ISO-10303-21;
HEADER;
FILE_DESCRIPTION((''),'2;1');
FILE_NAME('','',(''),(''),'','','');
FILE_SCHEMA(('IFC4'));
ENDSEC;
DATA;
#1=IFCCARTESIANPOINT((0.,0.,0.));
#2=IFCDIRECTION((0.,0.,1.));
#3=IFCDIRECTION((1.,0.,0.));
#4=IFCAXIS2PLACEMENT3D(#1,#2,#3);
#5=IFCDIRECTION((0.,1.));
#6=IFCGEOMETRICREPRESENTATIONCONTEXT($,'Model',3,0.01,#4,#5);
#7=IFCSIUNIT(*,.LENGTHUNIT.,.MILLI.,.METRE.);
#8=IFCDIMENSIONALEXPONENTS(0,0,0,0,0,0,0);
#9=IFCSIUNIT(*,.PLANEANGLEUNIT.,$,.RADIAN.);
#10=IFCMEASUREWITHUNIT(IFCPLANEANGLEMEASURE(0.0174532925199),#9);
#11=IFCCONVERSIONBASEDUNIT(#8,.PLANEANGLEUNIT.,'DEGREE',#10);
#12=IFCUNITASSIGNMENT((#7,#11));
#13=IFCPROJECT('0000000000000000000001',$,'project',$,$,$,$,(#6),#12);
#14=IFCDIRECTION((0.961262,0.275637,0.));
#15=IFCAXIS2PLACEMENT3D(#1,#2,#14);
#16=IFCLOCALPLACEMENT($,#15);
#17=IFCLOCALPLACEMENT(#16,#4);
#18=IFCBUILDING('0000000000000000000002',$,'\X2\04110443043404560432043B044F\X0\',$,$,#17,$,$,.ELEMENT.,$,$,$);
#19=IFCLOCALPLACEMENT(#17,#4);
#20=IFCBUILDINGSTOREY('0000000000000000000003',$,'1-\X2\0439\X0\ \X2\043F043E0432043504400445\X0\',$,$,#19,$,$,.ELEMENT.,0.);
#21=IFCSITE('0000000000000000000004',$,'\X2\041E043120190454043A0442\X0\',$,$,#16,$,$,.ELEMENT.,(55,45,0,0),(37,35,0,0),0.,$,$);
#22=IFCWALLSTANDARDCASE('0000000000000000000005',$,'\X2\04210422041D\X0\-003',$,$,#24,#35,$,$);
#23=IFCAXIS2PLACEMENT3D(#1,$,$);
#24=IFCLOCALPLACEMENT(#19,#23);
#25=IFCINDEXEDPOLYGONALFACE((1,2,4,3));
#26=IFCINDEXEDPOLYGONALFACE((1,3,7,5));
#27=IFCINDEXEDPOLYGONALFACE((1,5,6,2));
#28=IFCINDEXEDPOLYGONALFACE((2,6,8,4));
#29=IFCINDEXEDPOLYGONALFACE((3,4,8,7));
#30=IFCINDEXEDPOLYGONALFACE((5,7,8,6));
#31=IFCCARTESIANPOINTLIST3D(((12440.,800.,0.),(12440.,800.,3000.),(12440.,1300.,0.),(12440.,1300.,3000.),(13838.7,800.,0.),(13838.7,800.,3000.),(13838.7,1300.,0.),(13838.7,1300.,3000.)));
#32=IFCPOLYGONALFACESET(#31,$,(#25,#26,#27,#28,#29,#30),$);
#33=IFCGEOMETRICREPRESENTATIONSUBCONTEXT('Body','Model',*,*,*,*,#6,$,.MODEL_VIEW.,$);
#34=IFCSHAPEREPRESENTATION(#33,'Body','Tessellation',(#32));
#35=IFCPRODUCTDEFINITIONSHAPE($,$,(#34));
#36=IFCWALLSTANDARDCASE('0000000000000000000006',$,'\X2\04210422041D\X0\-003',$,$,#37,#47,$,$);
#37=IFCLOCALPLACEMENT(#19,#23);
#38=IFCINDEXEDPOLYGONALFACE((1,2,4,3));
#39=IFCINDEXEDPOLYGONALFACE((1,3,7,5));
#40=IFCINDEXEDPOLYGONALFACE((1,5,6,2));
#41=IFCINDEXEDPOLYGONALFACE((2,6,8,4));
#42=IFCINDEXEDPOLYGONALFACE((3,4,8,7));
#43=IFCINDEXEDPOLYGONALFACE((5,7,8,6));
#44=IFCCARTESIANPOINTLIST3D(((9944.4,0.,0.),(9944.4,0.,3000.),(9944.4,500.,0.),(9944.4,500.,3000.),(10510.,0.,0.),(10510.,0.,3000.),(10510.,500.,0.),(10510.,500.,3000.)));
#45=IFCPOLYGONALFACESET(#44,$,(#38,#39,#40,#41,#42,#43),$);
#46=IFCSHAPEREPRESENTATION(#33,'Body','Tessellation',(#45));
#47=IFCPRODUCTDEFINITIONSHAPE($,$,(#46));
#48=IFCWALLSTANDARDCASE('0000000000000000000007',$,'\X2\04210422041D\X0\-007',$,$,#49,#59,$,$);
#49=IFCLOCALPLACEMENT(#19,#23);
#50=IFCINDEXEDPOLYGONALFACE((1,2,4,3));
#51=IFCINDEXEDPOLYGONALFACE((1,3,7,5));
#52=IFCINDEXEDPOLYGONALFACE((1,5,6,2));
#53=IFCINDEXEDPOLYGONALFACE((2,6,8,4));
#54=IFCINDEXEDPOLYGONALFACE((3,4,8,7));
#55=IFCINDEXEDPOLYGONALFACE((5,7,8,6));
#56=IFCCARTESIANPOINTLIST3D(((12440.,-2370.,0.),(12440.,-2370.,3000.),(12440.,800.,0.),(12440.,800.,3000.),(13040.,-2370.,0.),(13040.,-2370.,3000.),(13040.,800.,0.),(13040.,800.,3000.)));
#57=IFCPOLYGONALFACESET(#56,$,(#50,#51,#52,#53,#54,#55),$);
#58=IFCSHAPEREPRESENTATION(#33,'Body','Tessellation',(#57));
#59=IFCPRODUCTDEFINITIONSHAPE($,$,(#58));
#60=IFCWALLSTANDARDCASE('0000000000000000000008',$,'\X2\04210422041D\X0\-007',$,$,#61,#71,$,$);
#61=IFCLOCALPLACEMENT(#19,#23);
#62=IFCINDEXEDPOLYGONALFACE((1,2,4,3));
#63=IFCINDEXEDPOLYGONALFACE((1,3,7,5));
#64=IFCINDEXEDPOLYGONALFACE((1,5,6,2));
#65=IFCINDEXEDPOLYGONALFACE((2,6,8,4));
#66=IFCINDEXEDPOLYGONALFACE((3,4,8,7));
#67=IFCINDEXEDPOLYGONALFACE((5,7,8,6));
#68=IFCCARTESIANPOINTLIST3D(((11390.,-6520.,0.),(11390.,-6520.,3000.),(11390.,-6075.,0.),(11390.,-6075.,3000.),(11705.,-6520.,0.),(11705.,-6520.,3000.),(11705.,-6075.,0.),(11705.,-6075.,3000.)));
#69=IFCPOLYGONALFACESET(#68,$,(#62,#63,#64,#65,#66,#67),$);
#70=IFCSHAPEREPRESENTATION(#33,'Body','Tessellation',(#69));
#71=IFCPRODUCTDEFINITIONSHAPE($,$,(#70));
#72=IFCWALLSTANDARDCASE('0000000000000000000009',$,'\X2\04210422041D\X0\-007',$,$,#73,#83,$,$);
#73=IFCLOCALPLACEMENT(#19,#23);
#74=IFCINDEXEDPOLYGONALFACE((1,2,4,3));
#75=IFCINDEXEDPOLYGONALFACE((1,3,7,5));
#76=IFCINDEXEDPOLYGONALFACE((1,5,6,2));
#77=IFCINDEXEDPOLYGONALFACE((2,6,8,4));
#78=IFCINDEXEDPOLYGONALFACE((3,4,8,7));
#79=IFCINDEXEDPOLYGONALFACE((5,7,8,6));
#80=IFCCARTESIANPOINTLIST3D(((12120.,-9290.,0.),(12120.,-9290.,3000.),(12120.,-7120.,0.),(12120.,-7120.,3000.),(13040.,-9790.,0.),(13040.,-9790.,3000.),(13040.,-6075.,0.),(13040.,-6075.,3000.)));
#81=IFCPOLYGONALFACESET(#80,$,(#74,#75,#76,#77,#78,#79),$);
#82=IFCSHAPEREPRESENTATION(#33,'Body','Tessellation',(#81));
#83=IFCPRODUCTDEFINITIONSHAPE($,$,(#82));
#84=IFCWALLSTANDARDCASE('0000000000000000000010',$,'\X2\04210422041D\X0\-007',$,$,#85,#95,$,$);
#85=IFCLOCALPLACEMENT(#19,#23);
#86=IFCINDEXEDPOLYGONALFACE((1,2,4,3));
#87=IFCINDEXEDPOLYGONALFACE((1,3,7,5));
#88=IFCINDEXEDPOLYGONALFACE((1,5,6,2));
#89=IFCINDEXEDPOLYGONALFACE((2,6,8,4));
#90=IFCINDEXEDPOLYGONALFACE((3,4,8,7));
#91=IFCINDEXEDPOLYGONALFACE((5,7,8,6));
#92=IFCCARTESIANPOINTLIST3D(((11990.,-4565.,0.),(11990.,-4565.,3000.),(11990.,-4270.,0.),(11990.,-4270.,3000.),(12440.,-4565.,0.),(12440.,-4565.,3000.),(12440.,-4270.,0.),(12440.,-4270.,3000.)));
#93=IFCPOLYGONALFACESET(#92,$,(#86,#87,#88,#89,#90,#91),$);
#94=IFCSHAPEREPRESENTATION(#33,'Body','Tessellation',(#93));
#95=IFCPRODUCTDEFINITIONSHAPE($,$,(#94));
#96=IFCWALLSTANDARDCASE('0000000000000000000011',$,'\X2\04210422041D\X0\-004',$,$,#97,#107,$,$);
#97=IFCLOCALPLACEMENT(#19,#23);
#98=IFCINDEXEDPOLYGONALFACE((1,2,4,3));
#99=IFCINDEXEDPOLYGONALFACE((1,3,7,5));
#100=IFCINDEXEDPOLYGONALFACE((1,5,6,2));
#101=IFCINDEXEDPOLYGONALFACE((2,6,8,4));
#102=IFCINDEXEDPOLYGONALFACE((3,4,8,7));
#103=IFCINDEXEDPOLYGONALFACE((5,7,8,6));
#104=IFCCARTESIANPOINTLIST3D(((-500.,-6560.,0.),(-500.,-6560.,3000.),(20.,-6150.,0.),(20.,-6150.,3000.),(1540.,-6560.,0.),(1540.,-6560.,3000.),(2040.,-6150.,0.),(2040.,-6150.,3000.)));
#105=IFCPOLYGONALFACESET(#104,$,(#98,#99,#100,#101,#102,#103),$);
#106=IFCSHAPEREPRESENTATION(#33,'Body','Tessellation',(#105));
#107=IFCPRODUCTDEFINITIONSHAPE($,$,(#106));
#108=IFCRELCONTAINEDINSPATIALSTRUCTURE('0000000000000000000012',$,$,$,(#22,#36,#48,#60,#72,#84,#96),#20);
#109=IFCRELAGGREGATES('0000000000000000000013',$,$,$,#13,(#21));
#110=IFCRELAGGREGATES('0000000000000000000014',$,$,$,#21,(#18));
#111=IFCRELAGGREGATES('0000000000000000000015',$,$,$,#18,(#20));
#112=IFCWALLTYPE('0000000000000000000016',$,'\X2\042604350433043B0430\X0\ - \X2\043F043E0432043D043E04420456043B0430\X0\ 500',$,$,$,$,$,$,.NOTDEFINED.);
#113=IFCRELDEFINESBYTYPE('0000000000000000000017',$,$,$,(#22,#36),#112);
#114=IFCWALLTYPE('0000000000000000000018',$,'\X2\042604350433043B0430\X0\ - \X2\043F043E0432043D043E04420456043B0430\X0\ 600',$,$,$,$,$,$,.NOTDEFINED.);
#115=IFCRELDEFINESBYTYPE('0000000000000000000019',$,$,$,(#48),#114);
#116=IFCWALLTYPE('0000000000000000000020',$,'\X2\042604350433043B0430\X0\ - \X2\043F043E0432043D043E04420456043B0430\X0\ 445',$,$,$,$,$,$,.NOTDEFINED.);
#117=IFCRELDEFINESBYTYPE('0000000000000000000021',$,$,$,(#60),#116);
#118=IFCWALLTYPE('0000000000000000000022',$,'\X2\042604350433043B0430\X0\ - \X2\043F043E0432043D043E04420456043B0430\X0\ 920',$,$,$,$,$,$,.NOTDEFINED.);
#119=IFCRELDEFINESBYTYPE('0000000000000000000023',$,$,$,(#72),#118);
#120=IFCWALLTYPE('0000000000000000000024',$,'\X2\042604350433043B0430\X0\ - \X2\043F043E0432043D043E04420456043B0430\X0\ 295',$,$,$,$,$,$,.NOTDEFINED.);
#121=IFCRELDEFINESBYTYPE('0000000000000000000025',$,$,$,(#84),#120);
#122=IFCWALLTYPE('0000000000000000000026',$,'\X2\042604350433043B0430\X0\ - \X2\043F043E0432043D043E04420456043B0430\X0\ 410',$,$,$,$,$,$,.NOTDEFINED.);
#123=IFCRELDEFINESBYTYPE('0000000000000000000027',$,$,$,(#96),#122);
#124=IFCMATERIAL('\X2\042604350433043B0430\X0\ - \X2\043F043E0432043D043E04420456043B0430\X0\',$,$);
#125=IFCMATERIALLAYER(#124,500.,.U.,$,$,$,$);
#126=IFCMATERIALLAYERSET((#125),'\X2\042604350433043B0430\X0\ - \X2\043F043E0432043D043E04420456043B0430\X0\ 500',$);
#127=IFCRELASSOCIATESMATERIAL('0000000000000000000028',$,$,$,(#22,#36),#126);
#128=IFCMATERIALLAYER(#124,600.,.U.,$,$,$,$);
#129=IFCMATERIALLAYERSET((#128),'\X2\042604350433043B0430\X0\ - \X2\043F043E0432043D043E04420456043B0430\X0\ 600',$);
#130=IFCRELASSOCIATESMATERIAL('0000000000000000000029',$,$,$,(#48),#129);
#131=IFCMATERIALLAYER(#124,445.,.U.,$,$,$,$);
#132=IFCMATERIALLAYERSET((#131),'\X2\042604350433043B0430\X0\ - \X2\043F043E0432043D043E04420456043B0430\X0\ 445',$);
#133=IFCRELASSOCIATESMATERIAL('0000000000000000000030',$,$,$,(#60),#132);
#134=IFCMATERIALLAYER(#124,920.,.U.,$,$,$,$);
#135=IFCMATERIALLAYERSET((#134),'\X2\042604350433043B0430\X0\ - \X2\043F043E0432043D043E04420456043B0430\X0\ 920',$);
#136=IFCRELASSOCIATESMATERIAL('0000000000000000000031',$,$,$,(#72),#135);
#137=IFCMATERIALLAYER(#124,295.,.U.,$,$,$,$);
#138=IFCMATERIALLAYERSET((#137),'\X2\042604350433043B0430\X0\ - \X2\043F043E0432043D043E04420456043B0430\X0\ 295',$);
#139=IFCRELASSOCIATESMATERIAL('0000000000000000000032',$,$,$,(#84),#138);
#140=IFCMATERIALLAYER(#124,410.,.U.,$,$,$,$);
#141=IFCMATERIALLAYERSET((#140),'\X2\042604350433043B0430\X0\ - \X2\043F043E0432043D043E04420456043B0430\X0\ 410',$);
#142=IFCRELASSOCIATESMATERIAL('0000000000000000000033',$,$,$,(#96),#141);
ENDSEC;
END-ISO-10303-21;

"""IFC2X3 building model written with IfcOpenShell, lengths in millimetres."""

from ifc_helpers import new_model, entity, si_unit, converted_unit, direction, frame, origin_with_axes, place, context, subcontext, project, spatial, polyline, outline, extrude, material, layer, layer_set, layer_usage, type_object, element, save


model = new_model("IFC2X3")

# Units and contexts
model_context = context("Model", 3, precision=0.01, world=origin_with_axes(), true_north=direction((0.0, 1.0)))
body_context = subcontext(model_context, "Body", "Model", "MODEL_VIEW")
ifc_project = project(units=[si_unit("LENGTHUNIT", "METRE", prefix="MILLI"), converted_unit("PLANEANGLEUNIT", "DEGREE", entity("IfcPlaneAngleMeasure", 0.0174532925199), si_unit("PLANEANGLEUNIT", "RADIAN"), dimensions=[0, 0, 0, 0, 0, 0, 0])], contexts=[model_context])

# Site, building, storey
site_placement = place(None, frame((0.0, 0.0, 0.0), z_axis=(0.0, 0.0, 1.0), x_axis=(0.961262, 0.275637, 0.0)))
site = spatial("IfcSite", under=ifc_project, at=site_placement, Name="Об’єкт", CompositionType="ELEMENT", RefLatitude=(55, 45, 0, 0), RefLongitude=(37, 35, 0, 0), RefElevation=0.0)
building_placement = place(site_placement, origin_with_axes())
building = spatial("IfcBuilding", under=site, at=building_placement, Name="Будівля", CompositionType="ELEMENT")
storey_placement = place(building_placement, origin_with_axes())
storey = spatial("IfcBuildingStorey", under=building, at=storey_placement, Name="1-й поверх", CompositionType="ELEMENT", Elevation=0.0)

# Walls
ifc_material_1 = material(Name="Цегла - повнотіла")
ifc_layer_1 = layer(ifc_material_1, 500.0, ventilated="UNKNOWN")
ifc_layer_set_1 = layer_set([ifc_layer_1], Name="Цегла - повнотіла 500")
wall_type_1 = type_object("IfcWallType", Name="Цегла - повнотіла 500", PredefinedType="NOTDEFINED")
ifc_layer_usage_1 = layer_usage(ifc_layer_set_1, "AXIS2", "POSITIVE", -500.0)
wall_1_placement = place(storey_placement, frame((12440.0, 1300.0, 0.0), z_axis=(0.0, 0.0, 1.0), x_axis=(1.0, 0.0, 0.0)))
element("IfcWallStandardCase", 1, at=wall_1_placement, inside=storey, type_object=wall_type_1, material=ifc_layer_usage_1, Name="СТН-003", context=body_context, shape_type="SweptSolid", body=[
    extrude(outline(polyline([(0.0, -500.0), (1398.7, -500.0), (1398.7, 0.0), (0.0, 0.0), (0.0, -500.0)])), origin_with_axes(), (0.0, 0.0, 1.0), 3000.0),
])
ifc_layer_usage_2 = layer_usage(ifc_layer_set_1, "AXIS2", "POSITIVE", 0.0)
wall_2_placement = place(storey_placement, frame((10510.0, 500.0, 0.0), z_axis=(0.0, 0.0, 1.0), x_axis=(-1.0, 0.0, 0.0)))
element("IfcWallStandardCase", 2, at=wall_2_placement, inside=storey, type_object=wall_type_1, material=ifc_layer_usage_2, Name="СТН-003", context=body_context, shape_type="SweptSolid", body=[
    extrude(outline(polyline([(0.0, 0.0), (565.6, 0.0), (565.6, 500.0), (0.0, 500.0), (0.0, 0.0)])), origin_with_axes(), (0.0, 0.0, 1.0), 3000.0),
])
ifc_layer_2 = layer(ifc_material_1, 600.0, ventilated="UNKNOWN")
ifc_layer_set_2 = layer_set([ifc_layer_2], Name="Цегла - повнотіла 600")
wall_type_2 = type_object("IfcWallType", Name="Цегла - повнотіла 600", PredefinedType="NOTDEFINED")
ifc_layer_usage_3 = layer_usage(ifc_layer_set_2, "AXIS2", "POSITIVE", 0.0)
wall_3_placement = place(storey_placement, frame((13040.0, -2370.0, 0.0), z_axis=(0.0, 0.0, 1.0), x_axis=(0.0, 1.0, 0.0)))
element("IfcWallStandardCase", 3, at=wall_3_placement, inside=storey, type_object=wall_type_2, material=ifc_layer_usage_3, Name="СТН-007", context=body_context, shape_type="SweptSolid", body=[
    extrude(outline(polyline([(0.0, 0.0), (3170.0, 0.0), (3170.0, 600.0), (0.0, 600.0), (0.0, 0.0)])), origin_with_axes(), (0.0, 0.0, 1.0), 3000.0),
])
ifc_layer_3 = layer(ifc_material_1, 445.0, ventilated="UNKNOWN")
ifc_layer_set_3 = layer_set([ifc_layer_3], Name="Цегла - повнотіла 445")
ifc_layer_usage_4 = layer_usage(ifc_layer_set_3, "AXIS2", "POSITIVE", 0.0)
wall_type_3 = type_object("IfcWallType", Name="Цегла - повнотіла 445", PredefinedType="NOTDEFINED")
wall_4_placement = place(storey_placement, frame((11390.0, -6520.0, 0.0), z_axis=(0.0, 0.0, 1.0), x_axis=(1.0, 0.0, 0.0)))
element("IfcWallStandardCase", 4, at=wall_4_placement, inside=storey, type_object=wall_type_3, material=ifc_layer_usage_4, Name="СТН-007", context=body_context, shape_type="SweptSolid", body=[
    extrude(outline(polyline([(0.0, 0.0), (315.0, 0.0), (315.0, 445.0), (0.0, 445.0), (0.0, 0.0)])), origin_with_axes(), (0.0, 0.0, 1.0), 3000.0),
])
ifc_layer_4 = layer(ifc_material_1, 920.0, ventilated="UNKNOWN")
ifc_layer_set_4 = layer_set([ifc_layer_4], Name="Цегла - повнотіла 920")
ifc_layer_usage_5 = layer_usage(ifc_layer_set_4, "AXIS2", "POSITIVE", 0.0)
wall_type_4 = type_object("IfcWallType", Name="Цегла - повнотіла 920", PredefinedType="NOTDEFINED")
wall_5_placement = place(storey_placement, frame((13040.0, -9790.0, 0.0), z_axis=(0.0, 0.0, 1.0), x_axis=(0.0, 1.0, 0.0)))
element("IfcWallStandardCase", 5, at=wall_5_placement, inside=storey, type_object=wall_type_4, material=ifc_layer_usage_5, Name="СТН-007", context=body_context, shape_type="SweptSolid", body=[
    extrude(outline(polyline([(0.0, 0.0), (3715.0, 0.0), (2670.0, 920.0), (500.0, 920.0), (0.0, 0.0)])), origin_with_axes(), (0.0, 0.0, 1.0), 3000.0),
])
ifc_layer_5 = layer(ifc_material_1, 295.0, ventilated="UNKNOWN")
ifc_layer_set_5 = layer_set([ifc_layer_5], Name="Цегла - повнотіла 295")
ifc_layer_usage_6 = layer_usage(ifc_layer_set_5, "AXIS2", "POSITIVE", -295.0)
wall_type_5 = type_object("IfcWallType", Name="Цегла - повнотіла 295", PredefinedType="NOTDEFINED")
wall_6_placement = place(storey_placement, frame((11990.0, -4270.0, 0.0), z_axis=(0.0, 0.0, 1.0), x_axis=(1.0, 0.0, 0.0)))
element("IfcWallStandardCase", 6, at=wall_6_placement, inside=storey, type_object=wall_type_5, material=ifc_layer_usage_6, Name="СТН-007", context=body_context, shape_type="SweptSolid", body=[
    extrude(outline(polyline([(0.0, -295.0), (450.0, -295.0), (450.0, 0.0), (0.0, 0.0), (0.0, -295.0)])), origin_with_axes(), (0.0, 0.0, 1.0), 3000.0),
])
ifc_layer_6 = layer(ifc_material_1, 410.0, ventilated="UNKNOWN")
ifc_layer_set_6 = layer_set([ifc_layer_6], Name="Цегла - повнотіла 410")
ifc_layer_usage_7 = layer_usage(ifc_layer_set_6, "AXIS2", "POSITIVE", -410.0)
wall_type_6 = type_object("IfcWallType", Name="Цегла - повнотіла 410", PredefinedType="NOTDEFINED")
wall_7_placement = place(storey_placement, frame((-500.0, -6150.0, 0.0), z_axis=(0.0, 0.0, 1.0), x_axis=(1.0, 0.0, 0.0)))
element("IfcWallStandardCase", 7, at=wall_7_placement, inside=storey, type_object=wall_type_6, material=ifc_layer_usage_7, Name="СТН-004", context=body_context, shape_type="SweptSolid", body=[
    extrude(outline(polyline([(0.0, -410.0), (2040.0, -410.0), (2540.0, 0.0), (520.0, 0.0), (0.0, -410.0)])), origin_with_axes(), (0.0, 0.0, 1.0), 3000.0),
])

save(model, "model.ifc")
